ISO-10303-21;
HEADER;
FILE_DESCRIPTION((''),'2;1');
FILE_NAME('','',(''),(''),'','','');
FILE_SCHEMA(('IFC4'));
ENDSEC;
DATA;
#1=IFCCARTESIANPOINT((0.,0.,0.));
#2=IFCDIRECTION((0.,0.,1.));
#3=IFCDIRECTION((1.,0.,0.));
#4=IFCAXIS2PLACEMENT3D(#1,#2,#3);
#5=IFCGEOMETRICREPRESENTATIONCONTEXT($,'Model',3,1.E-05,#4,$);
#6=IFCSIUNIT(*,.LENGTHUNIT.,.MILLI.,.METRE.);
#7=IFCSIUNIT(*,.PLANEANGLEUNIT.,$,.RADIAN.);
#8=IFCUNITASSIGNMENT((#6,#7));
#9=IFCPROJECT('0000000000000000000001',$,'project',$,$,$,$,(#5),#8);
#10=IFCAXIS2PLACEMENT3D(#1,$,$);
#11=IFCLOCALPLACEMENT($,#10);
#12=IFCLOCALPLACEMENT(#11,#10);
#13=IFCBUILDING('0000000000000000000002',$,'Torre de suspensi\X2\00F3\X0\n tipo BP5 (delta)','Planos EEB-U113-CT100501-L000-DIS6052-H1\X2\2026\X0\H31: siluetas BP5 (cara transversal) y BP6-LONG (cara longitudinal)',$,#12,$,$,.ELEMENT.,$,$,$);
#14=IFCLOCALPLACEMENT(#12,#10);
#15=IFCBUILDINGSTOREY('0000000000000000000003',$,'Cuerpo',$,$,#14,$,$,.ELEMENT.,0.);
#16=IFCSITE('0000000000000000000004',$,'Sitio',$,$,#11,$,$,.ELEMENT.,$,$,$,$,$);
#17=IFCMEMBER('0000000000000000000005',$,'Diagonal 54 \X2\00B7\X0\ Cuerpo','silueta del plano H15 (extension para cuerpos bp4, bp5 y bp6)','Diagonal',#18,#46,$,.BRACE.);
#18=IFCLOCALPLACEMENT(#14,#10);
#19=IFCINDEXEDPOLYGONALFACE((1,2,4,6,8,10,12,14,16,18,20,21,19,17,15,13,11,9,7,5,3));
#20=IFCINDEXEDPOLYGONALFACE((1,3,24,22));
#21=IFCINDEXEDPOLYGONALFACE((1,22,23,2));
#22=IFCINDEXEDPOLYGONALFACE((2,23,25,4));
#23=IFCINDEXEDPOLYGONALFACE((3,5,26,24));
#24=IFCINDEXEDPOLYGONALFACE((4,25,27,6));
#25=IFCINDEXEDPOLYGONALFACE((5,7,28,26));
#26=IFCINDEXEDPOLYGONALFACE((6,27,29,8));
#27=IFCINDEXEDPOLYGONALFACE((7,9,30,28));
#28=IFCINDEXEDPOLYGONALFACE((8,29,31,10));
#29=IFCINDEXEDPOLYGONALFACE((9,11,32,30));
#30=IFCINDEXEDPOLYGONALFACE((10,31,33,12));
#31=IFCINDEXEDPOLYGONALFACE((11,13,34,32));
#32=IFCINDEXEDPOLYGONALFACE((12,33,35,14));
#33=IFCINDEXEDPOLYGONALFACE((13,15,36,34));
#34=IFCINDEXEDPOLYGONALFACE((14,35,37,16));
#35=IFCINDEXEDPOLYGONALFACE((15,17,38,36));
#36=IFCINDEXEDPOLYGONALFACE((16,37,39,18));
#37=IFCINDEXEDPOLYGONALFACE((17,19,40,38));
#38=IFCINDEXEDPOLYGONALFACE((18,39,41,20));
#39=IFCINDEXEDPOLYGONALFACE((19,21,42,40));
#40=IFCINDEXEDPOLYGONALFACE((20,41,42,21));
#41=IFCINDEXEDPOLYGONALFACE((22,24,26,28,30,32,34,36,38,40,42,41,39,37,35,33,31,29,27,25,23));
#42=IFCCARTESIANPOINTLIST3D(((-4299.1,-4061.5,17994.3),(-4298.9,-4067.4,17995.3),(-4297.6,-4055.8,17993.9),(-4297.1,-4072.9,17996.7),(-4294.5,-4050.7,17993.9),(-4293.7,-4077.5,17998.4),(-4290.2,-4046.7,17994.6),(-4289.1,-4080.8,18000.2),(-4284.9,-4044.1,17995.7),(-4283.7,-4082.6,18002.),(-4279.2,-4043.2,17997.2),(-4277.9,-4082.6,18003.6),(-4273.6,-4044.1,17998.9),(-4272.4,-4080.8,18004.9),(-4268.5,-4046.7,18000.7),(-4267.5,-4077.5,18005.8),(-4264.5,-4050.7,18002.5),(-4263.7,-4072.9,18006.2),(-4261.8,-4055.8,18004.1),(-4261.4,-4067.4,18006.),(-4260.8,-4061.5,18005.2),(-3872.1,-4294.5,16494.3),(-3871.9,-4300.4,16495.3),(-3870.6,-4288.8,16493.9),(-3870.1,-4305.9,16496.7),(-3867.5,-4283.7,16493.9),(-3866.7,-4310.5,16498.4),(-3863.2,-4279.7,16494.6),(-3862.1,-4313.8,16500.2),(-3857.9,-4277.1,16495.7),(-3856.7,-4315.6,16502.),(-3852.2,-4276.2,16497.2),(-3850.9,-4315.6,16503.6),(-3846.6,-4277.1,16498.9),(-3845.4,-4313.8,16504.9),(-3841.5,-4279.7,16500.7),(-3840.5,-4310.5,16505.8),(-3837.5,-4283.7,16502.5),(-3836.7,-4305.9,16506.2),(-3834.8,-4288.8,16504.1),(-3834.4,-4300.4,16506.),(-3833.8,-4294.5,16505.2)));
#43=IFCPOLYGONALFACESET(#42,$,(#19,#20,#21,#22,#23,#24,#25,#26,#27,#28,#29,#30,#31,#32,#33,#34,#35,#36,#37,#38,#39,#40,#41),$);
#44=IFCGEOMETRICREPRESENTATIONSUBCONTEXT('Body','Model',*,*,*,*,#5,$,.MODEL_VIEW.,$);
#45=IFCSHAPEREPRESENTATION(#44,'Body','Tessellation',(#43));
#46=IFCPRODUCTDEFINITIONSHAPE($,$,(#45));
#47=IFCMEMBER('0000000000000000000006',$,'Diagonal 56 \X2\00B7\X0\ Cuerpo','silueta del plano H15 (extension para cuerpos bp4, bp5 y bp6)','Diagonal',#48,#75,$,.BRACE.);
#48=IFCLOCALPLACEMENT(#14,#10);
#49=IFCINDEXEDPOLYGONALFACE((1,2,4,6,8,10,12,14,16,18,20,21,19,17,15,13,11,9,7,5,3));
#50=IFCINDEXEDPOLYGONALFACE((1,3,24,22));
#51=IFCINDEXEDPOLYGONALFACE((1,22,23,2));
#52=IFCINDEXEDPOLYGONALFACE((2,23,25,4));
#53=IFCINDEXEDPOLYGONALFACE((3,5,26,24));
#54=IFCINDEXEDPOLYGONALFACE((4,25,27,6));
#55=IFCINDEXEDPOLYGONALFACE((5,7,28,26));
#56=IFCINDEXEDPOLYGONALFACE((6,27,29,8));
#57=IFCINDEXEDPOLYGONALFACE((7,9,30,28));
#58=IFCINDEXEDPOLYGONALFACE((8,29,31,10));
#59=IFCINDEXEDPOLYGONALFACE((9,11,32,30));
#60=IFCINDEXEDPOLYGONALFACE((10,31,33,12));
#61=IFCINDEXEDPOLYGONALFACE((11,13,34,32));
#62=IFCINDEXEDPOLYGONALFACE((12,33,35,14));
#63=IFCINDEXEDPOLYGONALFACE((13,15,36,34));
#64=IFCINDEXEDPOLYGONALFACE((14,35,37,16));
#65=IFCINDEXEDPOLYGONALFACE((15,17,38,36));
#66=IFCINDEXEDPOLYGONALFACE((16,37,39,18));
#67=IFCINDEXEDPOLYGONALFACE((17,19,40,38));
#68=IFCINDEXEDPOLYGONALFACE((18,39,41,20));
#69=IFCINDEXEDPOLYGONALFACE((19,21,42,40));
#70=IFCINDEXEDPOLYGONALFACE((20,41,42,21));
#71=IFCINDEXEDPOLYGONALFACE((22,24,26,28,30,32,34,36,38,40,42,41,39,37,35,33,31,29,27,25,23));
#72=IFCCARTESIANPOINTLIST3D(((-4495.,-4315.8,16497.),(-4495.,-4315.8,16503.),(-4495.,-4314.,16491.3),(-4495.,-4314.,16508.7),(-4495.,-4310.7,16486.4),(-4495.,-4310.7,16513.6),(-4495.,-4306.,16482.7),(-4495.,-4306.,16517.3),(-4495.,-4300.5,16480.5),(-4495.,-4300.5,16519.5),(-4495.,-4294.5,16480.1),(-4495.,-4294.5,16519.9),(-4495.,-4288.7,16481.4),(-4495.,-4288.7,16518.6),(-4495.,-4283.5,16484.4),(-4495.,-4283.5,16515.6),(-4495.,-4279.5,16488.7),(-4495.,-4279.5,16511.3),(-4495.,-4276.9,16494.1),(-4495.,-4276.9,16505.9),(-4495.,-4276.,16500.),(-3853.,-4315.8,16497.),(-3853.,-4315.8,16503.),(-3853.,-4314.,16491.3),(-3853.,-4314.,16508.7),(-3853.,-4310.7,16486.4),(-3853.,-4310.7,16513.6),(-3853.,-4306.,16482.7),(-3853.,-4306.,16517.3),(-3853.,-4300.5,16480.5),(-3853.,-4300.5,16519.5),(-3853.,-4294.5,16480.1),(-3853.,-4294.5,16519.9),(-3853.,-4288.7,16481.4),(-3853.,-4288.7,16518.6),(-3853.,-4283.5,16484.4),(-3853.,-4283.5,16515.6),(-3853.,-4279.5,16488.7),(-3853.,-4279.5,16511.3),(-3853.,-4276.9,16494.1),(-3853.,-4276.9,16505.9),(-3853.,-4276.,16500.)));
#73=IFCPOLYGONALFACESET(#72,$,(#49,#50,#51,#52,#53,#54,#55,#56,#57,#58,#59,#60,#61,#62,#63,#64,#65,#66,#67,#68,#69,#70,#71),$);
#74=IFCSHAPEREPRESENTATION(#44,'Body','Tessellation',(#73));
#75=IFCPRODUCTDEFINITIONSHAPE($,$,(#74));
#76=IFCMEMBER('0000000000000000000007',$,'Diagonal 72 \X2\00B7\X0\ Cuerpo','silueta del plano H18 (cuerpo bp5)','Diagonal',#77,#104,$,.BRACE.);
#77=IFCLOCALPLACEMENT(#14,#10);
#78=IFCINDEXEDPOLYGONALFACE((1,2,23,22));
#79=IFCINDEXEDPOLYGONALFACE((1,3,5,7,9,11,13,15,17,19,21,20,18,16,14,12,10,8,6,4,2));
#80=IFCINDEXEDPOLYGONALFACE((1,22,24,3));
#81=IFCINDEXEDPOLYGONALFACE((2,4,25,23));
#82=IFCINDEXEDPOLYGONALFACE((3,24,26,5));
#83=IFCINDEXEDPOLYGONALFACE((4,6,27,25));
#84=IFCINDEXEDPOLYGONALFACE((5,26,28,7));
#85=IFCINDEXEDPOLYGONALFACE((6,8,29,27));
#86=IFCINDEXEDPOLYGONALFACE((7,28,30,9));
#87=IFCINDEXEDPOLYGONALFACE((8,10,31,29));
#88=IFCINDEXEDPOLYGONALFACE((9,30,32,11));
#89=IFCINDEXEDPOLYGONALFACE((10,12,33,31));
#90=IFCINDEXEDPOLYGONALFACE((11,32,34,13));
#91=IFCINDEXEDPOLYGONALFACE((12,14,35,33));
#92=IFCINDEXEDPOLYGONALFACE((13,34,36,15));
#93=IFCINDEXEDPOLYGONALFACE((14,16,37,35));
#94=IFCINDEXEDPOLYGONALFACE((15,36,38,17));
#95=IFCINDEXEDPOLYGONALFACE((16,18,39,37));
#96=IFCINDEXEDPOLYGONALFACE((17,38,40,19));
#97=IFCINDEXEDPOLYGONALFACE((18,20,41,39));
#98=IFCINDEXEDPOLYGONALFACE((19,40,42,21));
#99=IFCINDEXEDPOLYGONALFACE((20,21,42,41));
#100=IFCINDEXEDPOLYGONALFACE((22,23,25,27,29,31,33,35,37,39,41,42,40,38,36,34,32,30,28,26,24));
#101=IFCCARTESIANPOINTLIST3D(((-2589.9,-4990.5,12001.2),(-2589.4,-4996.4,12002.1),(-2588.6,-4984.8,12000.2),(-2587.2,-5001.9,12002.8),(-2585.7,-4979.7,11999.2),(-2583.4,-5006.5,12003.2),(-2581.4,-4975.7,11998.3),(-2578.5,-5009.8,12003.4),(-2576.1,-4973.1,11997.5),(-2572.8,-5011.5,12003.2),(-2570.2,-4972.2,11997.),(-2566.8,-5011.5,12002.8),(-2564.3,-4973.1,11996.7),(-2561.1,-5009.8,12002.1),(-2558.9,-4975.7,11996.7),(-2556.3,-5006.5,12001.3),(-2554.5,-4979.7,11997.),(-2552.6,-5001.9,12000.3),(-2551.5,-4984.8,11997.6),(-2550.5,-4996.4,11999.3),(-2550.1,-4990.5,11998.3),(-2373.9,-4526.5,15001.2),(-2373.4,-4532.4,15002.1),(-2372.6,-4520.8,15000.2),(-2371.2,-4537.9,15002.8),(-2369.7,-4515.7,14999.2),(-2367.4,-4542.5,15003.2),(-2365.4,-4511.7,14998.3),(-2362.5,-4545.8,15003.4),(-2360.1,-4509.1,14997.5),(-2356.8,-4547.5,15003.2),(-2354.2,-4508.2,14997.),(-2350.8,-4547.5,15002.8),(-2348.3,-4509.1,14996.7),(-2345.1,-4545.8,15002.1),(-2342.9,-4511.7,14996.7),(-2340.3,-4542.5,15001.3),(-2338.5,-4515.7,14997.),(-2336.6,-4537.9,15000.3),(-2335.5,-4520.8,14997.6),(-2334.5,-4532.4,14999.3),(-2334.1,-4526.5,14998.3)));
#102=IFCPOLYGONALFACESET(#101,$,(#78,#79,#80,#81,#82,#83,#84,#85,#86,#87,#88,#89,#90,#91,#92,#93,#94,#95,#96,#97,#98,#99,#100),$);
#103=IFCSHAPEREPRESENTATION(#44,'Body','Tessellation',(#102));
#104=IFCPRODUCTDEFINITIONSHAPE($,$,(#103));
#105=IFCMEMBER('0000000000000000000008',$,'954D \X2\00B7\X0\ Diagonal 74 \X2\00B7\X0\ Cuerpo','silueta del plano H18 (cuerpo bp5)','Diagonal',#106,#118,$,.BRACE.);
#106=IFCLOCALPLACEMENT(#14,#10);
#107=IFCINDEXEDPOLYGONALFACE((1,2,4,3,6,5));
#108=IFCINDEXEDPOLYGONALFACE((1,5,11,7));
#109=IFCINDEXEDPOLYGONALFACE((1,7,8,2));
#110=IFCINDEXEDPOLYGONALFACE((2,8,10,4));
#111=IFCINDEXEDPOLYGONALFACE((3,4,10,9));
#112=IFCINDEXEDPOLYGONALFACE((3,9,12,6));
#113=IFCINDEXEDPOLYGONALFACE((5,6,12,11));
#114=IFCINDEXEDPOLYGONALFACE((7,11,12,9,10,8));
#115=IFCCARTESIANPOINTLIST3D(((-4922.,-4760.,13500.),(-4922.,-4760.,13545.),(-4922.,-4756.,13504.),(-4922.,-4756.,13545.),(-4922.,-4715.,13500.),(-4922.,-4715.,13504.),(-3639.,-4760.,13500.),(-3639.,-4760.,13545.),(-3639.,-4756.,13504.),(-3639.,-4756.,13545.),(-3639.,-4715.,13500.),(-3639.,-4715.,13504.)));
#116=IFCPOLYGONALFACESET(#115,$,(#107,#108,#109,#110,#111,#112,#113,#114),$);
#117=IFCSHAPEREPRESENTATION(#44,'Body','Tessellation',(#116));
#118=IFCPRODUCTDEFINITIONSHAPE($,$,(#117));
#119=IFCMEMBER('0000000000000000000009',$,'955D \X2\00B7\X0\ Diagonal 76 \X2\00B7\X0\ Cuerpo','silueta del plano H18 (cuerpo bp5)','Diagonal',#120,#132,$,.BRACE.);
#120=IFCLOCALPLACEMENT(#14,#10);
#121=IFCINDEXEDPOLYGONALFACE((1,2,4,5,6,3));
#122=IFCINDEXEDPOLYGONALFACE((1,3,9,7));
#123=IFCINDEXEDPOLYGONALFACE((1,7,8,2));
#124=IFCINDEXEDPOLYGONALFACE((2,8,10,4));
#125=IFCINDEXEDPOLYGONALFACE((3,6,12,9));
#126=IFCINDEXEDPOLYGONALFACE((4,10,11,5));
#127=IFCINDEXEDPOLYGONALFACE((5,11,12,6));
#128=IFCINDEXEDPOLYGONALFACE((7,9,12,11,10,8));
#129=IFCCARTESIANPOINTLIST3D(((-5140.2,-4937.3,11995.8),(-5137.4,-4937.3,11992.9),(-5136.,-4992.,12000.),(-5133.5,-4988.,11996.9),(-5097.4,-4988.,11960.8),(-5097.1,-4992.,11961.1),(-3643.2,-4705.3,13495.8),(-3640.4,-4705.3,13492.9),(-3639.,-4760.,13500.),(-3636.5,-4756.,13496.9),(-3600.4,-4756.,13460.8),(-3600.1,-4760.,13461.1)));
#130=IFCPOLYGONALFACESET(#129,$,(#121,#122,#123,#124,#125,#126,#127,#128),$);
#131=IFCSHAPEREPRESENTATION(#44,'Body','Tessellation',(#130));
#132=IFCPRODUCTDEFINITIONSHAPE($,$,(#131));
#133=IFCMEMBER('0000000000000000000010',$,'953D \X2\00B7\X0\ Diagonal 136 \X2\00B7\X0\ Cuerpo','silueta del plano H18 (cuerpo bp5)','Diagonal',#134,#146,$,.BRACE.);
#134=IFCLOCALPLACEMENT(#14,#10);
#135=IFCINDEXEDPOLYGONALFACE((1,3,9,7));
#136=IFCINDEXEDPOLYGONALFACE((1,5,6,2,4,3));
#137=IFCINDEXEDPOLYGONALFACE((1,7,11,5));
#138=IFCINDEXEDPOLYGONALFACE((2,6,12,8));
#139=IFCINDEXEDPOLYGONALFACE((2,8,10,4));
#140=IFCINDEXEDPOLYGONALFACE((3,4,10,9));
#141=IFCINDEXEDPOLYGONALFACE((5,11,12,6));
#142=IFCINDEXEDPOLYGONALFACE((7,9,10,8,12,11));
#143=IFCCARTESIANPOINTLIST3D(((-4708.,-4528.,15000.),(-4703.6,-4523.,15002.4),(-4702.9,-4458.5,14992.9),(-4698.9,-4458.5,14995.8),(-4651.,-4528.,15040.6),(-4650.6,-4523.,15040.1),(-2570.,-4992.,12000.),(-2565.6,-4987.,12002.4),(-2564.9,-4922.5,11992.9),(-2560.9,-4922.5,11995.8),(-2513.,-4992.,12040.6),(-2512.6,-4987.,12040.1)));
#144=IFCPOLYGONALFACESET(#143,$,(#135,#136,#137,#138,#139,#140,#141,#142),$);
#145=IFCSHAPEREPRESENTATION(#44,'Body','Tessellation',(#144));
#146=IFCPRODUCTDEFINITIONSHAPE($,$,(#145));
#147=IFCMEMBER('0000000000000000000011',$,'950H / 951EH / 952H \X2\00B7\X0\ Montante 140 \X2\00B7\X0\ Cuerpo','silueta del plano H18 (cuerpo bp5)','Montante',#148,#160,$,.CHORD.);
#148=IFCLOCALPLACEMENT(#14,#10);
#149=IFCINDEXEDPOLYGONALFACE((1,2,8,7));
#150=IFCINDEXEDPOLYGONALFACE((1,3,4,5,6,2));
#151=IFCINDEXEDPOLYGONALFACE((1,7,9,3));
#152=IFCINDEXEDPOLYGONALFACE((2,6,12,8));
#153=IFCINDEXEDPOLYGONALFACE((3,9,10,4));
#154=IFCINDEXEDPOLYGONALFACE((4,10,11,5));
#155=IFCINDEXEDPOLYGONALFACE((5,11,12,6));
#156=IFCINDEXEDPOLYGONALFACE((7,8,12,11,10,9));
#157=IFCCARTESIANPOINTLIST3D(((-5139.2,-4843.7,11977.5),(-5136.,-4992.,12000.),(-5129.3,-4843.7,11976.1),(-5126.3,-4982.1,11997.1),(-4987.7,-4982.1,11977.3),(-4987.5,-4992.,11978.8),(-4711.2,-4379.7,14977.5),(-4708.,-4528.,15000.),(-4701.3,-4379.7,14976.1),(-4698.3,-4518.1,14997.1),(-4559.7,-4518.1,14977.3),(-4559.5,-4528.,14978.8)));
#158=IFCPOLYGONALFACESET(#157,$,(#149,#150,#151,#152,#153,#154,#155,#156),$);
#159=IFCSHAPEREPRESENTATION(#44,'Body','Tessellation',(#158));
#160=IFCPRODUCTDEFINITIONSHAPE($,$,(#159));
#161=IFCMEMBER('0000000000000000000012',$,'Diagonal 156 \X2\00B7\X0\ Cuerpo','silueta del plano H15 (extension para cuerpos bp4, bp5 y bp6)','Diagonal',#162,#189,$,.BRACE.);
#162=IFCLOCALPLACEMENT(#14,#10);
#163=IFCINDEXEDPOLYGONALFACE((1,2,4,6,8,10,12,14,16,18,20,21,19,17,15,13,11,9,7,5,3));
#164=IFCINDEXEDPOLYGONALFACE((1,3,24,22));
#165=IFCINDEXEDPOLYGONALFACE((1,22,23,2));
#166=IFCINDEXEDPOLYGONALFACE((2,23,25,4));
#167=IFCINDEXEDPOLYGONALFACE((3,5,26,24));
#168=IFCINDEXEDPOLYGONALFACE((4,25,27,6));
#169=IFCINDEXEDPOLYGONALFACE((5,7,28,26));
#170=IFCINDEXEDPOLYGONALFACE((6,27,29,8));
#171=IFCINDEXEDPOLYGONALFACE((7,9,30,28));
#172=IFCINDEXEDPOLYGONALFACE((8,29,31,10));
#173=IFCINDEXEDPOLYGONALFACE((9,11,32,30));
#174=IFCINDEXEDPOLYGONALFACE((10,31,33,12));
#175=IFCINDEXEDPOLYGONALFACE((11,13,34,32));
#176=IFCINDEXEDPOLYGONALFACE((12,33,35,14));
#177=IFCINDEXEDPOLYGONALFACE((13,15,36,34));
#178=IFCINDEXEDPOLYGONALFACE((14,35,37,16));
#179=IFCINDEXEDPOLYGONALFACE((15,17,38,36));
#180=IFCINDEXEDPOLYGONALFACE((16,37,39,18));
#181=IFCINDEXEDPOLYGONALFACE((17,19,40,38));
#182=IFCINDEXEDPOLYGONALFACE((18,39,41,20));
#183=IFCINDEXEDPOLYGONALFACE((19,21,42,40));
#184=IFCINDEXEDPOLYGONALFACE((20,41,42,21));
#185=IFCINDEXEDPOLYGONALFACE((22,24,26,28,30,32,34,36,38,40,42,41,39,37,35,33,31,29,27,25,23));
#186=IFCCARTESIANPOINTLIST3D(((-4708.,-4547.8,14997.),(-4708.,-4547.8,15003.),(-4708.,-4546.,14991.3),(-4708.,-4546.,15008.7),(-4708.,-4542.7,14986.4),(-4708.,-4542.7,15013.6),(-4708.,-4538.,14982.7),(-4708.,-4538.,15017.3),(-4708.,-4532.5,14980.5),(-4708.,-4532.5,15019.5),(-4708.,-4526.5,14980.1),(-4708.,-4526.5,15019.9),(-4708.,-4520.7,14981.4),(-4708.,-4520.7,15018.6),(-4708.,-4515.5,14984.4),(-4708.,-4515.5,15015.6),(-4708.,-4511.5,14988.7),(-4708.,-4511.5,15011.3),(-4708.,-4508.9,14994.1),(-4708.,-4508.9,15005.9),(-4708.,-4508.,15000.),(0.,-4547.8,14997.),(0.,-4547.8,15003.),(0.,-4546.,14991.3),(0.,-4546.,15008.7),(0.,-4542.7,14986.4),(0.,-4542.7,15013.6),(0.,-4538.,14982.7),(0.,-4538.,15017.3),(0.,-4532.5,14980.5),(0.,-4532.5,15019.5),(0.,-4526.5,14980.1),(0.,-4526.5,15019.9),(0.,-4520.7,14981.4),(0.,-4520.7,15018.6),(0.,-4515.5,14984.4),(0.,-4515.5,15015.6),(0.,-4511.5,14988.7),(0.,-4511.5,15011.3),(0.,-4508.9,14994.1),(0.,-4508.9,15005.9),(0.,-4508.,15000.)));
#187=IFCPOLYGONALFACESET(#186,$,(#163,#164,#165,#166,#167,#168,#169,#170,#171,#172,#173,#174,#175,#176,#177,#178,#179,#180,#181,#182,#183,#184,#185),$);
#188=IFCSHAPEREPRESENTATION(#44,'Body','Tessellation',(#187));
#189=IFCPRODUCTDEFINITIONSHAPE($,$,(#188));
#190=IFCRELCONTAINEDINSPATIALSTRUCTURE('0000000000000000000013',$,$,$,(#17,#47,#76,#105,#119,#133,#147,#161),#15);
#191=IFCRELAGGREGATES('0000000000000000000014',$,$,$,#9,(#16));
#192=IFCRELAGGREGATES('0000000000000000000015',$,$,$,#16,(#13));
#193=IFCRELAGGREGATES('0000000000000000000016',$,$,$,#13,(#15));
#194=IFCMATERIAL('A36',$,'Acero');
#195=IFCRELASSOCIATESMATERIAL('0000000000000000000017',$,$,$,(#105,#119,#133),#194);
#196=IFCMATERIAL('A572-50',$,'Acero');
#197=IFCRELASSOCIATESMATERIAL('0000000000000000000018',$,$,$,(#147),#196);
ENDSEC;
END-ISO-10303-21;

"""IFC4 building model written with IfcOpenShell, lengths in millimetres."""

from ifc_helpers import new_model, si_unit, frame, frame_2d, origin, origin_with_axes, place, context, subcontext, project, spatial, circle, l_section, extrude, material, element, save


model = new_model("IFC4")

# Units and contexts
model_context = context("Model", 3, precision=1e-05, world=origin_with_axes())
body_context = subcontext(model_context, "Body", "Model", "MODEL_VIEW")
ifc_project = project(units=[si_unit("LENGTHUNIT", "METRE", prefix="MILLI"), si_unit("PLANEANGLEUNIT", "RADIAN")], contexts=[model_context])

# Site, building, storey
site_placement = place(None, origin())
site = spatial("IfcSite", under=ifc_project, at=site_placement, Name="Sitio", CompositionType="ELEMENT")
building_placement = place(site_placement, origin())
building = spatial("IfcBuilding", under=site, at=building_placement, Name="Torre de suspensión tipo BP5 (delta)", Description="Planos EEB-U113-CT100501-L000-DIS6052-H1…H31: siluetas BP5 (cara transversal) y BP6-LONG (cara longitudinal)", CompositionType="ELEMENT")
storey_placement = place(building_placement, origin())
storey = spatial("IfcBuildingStorey", under=building, at=storey_placement, Name="Cuerpo", CompositionType="ELEMENT", Elevation=0.0)

# Members
member_1_placement = place(storey_placement, frame((-3853.0, -4296.0, 16500.0), z_axis=(-0.270784, 0.147758, 0.951233), x_axis=(0.040455, 0.989024, -0.142112)))
element("IfcMember", 1, at=member_1_placement, inside=storey, Name="Diagonal 54 · Cuerpo", Description="silueta del plano H15 (extension para cuerpos bp4, bp5 y bp6)", ObjectType="Diagonal", PredefinedType="BRACE", context=body_context, shape_type="SweptSolid", body=[
    extrude(circle(Radius=20.0), None, (0.0, 0.0, 1.0), 1576.9),
])
member_2_placement = place(storey_placement, frame((-3853.0, -4296.0, 16500.0), z_axis=(-1.0, 0.0, 0.0), x_axis=(0.0, 1.0, 0.0)))
element("IfcMember", 2, at=member_2_placement, inside=storey, Name="Diagonal 56 · Cuerpo", Description="silueta del plano H15 (extension para cuerpos bp4, bp5 y bp6)", ObjectType="Diagonal", PredefinedType="BRACE", context=body_context, shape_type="SweptSolid", body=[
    extrude(circle(Radius=20.0), None, (0.0, 0.0, 1.0), 642.0),
])
member_3_placement = place(storey_placement, frame((-2570.0, -4992.0, 12000.0), z_axis=(0.070975, 0.152464, 0.985757), x_axis=(-0.010949, 0.988309, -0.15207)))
element("IfcMember", 3, at=member_3_placement, inside=storey, Name="Diagonal 72 · Cuerpo", Description="silueta del plano H18 (cuerpo bp5)", ObjectType="Diagonal", PredefinedType="BRACE", context=body_context, shape_type="SweptSolid", body=[
    extrude(circle(Radius=20.0), None, (0.0, 0.0, 1.0), 3043.3),
])
ifc_material_1 = material(Name="A36", Category="Acero")
member_4_placement = place(storey_placement, frame((-4922.0, -4760.0, 13500.0), z_axis=(1.0, 0.0, 0.0), x_axis=(0.0, 1.0, 0.0)))
element("IfcMember", 4, at=member_4_placement, inside=storey, material=ifc_material_1, Name="954D · Diagonal 74 · Cuerpo", Description="silueta del plano H18 (cuerpo bp5)", ObjectType="Diagonal", PredefinedType="BRACE", context=body_context, shape_type="SweptSolid", body=[
    extrude(l_section(Depth=45.0, Width=45.0, Thickness=4.0, at=frame_2d((22.5, 22.5))), None, (0.0, 0.0, 1.0), 1283.0),
])
member_5_placement = place(storey_placement, frame((-3639.0, -4760.0, 13500.0), z_axis=(-0.702203, -0.108825, -0.70361), x_axis=(-0.076874, 0.994061, -0.077028)))
element("IfcMember", 5, at=member_5_placement, inside=storey, material=ifc_material_1, Name="955D · Diagonal 76 · Cuerpo", Description="silueta del plano H18 (cuerpo bp5)", ObjectType="Diagonal", PredefinedType="BRACE", context=body_context, shape_type="SweptSolid", body=[
    extrude(l_section(Depth=55.0, Width=55.0, Thickness=4.0, at=frame_2d((27.5, 27.5))), None, (0.0, 0.0, 1.0), 2131.9),
])
member_6_placement = place(storey_placement, frame((-4708.0, -4528.0, 15000.0), z_axis=(0.575815, -0.124966, -0.807973), x_axis=(0.072526, 0.992161, -0.101767)))
element("IfcMember", 6, at=member_6_placement, inside=storey, material=ifc_material_1, Name="953D · Diagonal 136 · Cuerpo", Description="silueta del plano H18 (cuerpo bp5)", ObjectType="Diagonal", PredefinedType="BRACE", context=body_context, shape_type="SweptSolid", body=[
    extrude(l_section(Depth=70.0, Width=70.0, Thickness=5.0, at=frame_2d((35.0, 35.0))), None, (0.0, 0.0, 1.0), 3713.0),
])
ifc_material_2 = material(Name="A572-50", Category="Acero")
member_7_placement = place(storey_placement, frame((-4708.0, -4528.0, 15000.0), z_axis=(-0.139609, -0.151352, -0.978571), x_axis=(-0.021376, 0.98848, -0.149835)))
element("IfcMember", 7, at=member_7_placement, inside=storey, material=ifc_material_2, Name="950H / 951EH / 952H · Montante 140 · Cuerpo", Description="silueta del plano H18 (cuerpo bp5)", ObjectType="Montante", PredefinedType="CHORD", context=body_context, shape_type="SweptSolid", body=[
    extrude(l_section(Depth=150.0, Width=150.0, Thickness=10.0, at=frame_2d((75.0, 75.0))), None, (0.0, 0.0, 1.0), 3065.7),
])
member_8_placement = place(storey_placement, frame((-4708.0, -4528.0, 15000.0), z_axis=(1.0, 0.0, 0.0), x_axis=(0.0, 1.0, 0.0)))
element("IfcMember", 8, at=member_8_placement, inside=storey, Name="Diagonal 156 · Cuerpo", Description="silueta del plano H15 (extension para cuerpos bp4, bp5 y bp6)", ObjectType="Diagonal", PredefinedType="BRACE", context=body_context, shape_type="SweptSolid", body=[
    extrude(circle(Radius=20.0), None, (0.0, 0.0, 1.0), 4708.0),
])

save(model, "model.ifc")
